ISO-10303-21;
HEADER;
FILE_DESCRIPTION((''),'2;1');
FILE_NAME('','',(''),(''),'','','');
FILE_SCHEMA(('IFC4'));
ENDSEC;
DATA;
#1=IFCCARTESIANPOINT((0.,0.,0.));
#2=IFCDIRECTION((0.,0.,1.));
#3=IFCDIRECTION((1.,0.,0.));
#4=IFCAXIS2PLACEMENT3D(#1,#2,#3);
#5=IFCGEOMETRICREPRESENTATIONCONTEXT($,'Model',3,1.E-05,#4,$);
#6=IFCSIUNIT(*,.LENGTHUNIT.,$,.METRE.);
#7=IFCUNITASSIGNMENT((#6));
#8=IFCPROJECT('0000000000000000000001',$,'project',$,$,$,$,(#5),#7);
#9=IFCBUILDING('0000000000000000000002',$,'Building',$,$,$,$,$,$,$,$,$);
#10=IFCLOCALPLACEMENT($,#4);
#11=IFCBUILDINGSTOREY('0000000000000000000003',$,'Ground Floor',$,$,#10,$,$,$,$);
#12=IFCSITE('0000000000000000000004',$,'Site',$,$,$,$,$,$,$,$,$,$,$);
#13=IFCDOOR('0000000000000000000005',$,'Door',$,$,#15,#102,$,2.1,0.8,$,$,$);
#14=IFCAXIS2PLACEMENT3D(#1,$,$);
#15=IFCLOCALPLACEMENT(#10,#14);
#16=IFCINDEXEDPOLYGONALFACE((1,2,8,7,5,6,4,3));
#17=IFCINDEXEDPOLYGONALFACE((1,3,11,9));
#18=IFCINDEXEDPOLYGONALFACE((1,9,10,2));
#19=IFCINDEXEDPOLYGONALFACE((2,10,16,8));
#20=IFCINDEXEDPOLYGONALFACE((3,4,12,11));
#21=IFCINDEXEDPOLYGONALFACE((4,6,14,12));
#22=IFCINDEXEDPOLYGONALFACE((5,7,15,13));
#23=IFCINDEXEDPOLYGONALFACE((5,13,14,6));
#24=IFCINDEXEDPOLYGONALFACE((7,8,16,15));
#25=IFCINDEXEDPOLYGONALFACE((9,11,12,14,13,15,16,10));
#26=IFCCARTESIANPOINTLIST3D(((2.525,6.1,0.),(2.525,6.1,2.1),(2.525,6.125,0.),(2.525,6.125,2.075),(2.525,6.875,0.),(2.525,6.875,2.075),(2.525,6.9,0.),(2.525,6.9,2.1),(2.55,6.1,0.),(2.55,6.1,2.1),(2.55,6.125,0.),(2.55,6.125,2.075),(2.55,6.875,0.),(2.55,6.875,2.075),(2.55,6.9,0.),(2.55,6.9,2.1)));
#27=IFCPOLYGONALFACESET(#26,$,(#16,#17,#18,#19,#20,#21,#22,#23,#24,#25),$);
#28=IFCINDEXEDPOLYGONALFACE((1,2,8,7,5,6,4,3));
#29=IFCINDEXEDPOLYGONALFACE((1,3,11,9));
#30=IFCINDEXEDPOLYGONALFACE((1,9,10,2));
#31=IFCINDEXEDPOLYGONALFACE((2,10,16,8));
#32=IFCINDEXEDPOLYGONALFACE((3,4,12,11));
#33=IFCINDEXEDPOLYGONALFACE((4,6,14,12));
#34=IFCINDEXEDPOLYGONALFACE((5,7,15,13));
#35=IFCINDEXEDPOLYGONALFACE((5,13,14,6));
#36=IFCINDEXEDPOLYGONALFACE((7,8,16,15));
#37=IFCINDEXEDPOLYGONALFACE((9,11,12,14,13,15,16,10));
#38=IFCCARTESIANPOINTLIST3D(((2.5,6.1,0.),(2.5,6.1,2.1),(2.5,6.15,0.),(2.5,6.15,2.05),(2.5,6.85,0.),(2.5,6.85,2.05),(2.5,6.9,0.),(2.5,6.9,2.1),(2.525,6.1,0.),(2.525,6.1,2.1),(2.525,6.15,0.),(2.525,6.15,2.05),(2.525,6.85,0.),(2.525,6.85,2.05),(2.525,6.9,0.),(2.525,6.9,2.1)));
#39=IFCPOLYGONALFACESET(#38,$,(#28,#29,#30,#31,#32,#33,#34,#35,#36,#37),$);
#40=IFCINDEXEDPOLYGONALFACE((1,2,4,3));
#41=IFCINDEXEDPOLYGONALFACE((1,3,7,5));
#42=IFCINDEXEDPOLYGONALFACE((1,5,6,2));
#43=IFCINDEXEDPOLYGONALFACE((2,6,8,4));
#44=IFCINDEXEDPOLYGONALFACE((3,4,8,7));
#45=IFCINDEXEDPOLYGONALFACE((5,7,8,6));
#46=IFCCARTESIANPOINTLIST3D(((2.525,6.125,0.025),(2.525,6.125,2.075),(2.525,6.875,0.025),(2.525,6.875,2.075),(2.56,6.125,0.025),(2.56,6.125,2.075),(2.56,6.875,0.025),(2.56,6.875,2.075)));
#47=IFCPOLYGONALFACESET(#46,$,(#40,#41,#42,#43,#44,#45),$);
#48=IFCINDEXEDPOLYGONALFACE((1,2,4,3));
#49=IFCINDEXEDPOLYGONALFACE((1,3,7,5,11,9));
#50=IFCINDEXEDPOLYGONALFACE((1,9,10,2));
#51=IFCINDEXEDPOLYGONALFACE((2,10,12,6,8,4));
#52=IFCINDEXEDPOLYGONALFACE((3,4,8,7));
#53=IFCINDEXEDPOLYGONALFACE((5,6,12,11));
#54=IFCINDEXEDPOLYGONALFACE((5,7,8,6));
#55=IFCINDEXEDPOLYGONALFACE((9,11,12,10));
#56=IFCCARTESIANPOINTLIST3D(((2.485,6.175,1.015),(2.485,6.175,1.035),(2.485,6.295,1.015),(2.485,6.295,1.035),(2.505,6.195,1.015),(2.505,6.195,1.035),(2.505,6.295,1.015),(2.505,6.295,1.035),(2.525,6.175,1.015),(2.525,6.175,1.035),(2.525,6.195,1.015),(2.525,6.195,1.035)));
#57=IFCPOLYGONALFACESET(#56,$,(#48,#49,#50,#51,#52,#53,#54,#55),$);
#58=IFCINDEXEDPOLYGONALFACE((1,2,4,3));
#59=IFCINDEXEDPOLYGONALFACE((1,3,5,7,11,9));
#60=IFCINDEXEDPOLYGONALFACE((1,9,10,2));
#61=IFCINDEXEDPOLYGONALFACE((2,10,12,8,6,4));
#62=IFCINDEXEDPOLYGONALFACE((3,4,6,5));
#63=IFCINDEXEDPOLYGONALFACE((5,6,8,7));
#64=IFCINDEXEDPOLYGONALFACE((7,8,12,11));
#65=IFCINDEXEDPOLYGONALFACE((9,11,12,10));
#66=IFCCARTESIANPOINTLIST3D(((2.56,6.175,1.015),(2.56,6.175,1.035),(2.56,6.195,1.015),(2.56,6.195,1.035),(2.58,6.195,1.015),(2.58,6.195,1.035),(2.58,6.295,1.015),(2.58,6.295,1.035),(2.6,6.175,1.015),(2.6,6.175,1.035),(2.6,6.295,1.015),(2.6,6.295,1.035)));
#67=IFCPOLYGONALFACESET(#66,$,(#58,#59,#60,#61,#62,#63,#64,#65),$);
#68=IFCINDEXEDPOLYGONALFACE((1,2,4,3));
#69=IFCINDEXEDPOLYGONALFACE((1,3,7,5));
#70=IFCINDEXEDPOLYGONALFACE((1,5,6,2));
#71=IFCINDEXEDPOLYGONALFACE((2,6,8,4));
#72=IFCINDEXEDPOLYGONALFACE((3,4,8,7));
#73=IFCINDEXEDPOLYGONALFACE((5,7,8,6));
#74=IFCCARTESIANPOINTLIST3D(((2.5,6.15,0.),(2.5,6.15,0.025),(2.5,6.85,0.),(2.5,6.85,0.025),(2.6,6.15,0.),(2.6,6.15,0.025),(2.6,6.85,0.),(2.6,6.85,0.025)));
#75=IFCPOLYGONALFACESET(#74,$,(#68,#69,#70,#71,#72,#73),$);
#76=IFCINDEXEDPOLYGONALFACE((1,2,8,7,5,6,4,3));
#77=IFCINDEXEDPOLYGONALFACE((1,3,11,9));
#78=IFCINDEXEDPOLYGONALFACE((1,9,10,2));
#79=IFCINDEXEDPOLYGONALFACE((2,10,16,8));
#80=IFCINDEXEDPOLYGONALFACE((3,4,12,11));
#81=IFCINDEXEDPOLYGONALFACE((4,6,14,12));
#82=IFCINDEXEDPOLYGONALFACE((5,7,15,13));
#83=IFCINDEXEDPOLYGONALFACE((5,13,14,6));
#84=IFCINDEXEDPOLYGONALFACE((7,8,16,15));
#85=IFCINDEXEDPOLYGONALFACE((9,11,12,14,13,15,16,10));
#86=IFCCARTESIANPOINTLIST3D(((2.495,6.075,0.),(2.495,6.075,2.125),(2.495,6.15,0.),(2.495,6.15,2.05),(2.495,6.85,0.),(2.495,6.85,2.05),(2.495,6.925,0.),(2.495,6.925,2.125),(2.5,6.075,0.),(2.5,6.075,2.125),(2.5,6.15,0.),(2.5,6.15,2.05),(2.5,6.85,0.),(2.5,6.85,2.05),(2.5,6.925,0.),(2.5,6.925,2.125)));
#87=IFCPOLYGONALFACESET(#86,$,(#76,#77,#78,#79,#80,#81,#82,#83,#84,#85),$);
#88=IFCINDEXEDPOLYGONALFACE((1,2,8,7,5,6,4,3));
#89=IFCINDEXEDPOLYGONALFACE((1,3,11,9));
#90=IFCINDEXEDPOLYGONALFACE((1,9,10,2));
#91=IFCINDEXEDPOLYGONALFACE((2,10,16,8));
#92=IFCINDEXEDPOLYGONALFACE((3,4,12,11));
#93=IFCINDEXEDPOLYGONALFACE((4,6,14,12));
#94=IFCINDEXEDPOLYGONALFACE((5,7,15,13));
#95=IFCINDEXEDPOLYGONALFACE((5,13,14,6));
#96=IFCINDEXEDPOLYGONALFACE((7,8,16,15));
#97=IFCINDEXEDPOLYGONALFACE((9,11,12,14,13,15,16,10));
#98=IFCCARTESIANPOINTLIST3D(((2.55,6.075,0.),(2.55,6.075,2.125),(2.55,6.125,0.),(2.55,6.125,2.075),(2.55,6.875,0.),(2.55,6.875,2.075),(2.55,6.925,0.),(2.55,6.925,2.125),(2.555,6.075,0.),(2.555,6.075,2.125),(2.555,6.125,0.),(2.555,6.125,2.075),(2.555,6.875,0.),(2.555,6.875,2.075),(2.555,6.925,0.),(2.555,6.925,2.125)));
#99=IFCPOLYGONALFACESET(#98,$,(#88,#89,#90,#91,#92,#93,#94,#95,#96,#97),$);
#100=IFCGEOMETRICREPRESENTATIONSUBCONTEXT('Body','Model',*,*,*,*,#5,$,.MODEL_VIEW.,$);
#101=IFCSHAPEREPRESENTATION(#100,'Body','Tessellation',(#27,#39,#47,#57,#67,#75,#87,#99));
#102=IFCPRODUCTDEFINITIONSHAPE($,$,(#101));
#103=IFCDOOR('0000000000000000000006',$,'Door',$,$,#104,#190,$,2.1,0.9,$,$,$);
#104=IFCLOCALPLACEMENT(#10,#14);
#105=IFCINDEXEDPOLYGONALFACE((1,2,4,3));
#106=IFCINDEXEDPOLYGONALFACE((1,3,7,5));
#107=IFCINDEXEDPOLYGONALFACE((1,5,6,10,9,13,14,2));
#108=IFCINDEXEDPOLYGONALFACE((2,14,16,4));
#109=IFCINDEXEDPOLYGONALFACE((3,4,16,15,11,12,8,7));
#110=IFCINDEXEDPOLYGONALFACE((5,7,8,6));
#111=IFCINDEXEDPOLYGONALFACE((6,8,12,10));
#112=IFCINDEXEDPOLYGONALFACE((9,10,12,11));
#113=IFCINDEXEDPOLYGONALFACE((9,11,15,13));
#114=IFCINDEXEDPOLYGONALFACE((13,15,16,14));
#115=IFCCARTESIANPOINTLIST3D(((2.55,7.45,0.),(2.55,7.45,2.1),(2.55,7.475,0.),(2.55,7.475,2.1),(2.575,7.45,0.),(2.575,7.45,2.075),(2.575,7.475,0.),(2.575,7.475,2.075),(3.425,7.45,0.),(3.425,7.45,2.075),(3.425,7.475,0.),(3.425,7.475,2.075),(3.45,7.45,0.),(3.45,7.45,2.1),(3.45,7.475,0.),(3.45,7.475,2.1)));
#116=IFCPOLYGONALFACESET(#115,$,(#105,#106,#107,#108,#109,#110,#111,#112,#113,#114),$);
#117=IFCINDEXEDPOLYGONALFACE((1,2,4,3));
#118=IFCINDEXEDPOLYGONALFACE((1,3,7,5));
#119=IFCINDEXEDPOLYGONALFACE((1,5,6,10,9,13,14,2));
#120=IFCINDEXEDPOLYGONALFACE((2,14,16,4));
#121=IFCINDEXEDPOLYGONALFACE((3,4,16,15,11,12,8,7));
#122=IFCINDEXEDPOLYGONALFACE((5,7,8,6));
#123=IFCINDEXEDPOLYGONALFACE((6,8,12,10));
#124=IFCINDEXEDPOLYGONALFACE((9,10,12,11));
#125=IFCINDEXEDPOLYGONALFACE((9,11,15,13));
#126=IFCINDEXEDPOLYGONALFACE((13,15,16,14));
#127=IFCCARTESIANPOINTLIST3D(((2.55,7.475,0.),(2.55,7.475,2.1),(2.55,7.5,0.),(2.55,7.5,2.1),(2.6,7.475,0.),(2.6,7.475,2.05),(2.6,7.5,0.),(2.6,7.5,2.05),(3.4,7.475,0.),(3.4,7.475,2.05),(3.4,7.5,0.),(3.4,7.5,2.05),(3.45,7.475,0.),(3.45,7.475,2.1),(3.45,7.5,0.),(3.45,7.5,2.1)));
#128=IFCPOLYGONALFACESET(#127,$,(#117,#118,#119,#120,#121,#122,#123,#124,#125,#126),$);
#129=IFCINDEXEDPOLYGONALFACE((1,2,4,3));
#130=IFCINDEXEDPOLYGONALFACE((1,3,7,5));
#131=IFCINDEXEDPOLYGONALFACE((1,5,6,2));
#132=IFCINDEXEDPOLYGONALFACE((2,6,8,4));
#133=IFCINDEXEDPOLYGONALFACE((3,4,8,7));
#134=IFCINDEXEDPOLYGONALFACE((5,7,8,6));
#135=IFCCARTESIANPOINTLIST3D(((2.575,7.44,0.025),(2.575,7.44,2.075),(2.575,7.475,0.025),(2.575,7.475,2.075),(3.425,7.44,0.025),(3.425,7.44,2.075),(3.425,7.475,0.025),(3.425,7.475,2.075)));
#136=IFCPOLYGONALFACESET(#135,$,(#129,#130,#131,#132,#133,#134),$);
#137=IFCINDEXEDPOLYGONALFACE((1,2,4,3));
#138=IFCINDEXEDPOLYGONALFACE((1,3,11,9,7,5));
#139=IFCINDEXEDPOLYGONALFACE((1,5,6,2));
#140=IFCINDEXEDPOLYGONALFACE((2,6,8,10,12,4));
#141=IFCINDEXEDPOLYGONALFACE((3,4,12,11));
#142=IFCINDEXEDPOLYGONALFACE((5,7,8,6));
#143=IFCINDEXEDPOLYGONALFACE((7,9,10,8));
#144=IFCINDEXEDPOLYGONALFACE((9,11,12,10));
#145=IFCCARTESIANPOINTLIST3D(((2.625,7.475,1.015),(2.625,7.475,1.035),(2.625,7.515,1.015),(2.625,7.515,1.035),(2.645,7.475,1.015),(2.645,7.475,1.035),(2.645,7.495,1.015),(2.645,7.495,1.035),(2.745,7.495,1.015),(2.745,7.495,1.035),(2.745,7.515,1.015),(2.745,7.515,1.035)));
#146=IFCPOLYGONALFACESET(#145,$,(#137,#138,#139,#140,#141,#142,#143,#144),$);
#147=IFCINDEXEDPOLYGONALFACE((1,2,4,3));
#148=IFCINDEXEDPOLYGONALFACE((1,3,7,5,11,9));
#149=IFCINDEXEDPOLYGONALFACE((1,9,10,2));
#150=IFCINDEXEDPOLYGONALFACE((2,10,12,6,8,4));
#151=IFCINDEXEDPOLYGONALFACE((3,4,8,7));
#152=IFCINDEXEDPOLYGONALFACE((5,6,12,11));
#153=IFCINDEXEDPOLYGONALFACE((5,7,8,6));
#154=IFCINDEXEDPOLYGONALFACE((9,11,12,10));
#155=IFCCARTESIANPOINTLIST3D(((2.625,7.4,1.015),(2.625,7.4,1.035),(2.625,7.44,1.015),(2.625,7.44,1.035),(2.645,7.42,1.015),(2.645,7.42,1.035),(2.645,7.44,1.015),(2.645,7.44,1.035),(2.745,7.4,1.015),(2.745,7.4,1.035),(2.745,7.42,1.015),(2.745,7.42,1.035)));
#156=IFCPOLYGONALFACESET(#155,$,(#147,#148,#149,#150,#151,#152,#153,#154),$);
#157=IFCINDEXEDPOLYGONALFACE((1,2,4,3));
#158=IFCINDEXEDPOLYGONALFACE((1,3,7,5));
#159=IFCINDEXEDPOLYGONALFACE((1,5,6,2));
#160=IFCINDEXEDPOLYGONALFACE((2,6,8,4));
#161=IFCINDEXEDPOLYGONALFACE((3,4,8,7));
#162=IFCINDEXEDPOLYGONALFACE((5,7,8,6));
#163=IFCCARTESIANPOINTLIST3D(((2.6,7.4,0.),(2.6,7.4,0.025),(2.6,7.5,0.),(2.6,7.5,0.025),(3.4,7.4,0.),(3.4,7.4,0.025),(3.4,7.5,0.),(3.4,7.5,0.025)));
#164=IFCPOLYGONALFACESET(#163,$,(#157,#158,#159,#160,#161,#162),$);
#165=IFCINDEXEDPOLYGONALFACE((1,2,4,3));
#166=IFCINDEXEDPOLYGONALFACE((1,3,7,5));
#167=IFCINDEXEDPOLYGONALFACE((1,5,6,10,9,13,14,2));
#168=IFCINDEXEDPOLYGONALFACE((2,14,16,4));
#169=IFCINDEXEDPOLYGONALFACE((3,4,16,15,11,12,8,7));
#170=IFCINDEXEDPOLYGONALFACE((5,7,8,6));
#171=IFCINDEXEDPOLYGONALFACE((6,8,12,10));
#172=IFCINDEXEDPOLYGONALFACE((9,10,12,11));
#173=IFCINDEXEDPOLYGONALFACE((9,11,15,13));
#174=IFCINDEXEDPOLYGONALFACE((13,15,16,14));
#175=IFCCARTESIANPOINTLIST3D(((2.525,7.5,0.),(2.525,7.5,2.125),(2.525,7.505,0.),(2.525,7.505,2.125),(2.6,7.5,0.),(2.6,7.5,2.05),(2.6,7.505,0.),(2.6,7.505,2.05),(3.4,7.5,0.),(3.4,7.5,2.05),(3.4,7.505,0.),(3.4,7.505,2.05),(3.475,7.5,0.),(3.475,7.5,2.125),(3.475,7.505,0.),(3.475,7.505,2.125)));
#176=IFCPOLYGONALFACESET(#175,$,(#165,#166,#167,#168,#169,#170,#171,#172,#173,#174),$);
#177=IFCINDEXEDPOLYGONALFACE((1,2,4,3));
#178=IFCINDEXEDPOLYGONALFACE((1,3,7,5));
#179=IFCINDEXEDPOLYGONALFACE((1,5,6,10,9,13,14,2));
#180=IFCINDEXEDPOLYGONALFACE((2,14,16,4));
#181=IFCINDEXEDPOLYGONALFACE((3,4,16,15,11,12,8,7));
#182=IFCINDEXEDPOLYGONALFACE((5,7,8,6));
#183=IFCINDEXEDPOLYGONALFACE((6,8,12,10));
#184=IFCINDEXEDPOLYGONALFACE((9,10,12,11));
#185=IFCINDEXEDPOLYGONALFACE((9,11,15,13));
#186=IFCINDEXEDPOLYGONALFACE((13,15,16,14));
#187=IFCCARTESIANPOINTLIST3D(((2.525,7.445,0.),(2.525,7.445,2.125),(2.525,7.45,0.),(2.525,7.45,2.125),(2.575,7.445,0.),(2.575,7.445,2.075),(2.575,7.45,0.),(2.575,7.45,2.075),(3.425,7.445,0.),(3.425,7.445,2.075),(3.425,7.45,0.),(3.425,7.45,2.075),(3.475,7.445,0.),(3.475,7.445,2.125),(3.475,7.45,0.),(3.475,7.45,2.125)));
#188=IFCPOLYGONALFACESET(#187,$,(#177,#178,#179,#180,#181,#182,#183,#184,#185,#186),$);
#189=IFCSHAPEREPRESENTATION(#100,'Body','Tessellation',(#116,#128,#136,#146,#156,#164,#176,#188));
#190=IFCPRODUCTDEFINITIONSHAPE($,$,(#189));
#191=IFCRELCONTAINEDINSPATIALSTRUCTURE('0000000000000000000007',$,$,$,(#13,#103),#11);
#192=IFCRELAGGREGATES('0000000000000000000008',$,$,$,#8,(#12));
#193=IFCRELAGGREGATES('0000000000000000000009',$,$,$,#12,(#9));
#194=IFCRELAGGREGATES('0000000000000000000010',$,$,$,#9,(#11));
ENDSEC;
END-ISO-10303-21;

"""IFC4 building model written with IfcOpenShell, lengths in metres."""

from ifc_helpers import new_model, si_unit, frame, origin_with_axes, place, context, subcontext, project, spatial, line, indexed_curve, outline, extrude, element, save


model = new_model("IFC4")

# Units and contexts
model_context = context("Model", 3, precision=1e-05, world=origin_with_axes())
body_context = subcontext(model_context, "Body", "Model", "MODEL_VIEW")
ifc_project = project(units=[si_unit("LENGTHUNIT", "METRE")], contexts=[model_context])

# Site, building, storey
site = spatial("IfcSite", under=ifc_project, Name="Site")
building = spatial("IfcBuilding", under=site, Name="Building")
storey_placement = place(None, origin_with_axes())
storey = spatial("IfcBuildingStorey", under=building, at=storey_placement, Name="Ground Floor")

# Doors
door_1_placement = place(storey_placement, frame((2.5, 6.9, 0.0), z_axis=(0.0, 0.0, 1.0), x_axis=(0.0, -1.0, 0.0)))
element("IfcDoor", 1, at=door_1_placement, inside=storey, Name="Door", OverallHeight=2.1, OverallWidth=0.8, context=body_context, shape_type="SweptSolid", body=[
    extrude(outline(indexed_curve([(0.0, 0.0), (0.0, 2.1), (0.8, 2.1), (0.8, 0.0), (0.775, 0.0), (0.775, 2.075), (0.025, 2.075), (0.025, 0.0)], segments=[line(1, 2, 3, 4, 5, 6, 7, 8, 1)])), frame((0.0, 0.025, 0.0), z_axis=(0.0, -1.0, 0.0), x_axis=(1.0, 0.0, 0.0)), (0.0, 0.0, -1.0), 0.025),
    extrude(outline(indexed_curve([(0.0, 0.0), (0.0, 2.1), (0.8, 2.1), (0.8, 0.0), (0.75, 0.0), (0.75, 2.05), (0.05, 2.05), (0.05, 0.0)], segments=[line(1, 2, 3, 4, 5, 6, 7, 8, 1)])), frame((0.0, 0.0, 0.0), z_axis=(0.0, -1.0, 0.0), x_axis=(1.0, 0.0, 0.0)), (0.0, 0.0, -1.0), 0.025),
    extrude(outline(indexed_curve([(0.0, 0.0), (0.75, 0.0), (0.75, 0.035), (0.0, 0.035)], segments=[line(1, 2, 3, 4, 1)])), frame((0.025, 0.025, 0.025), z_axis=(0.0, 0.0, 1.0), x_axis=(1.0, 0.0, 0.0)), (0.0, 0.0, 1.0), 2.05),
    extrude(outline(indexed_curve([(0.0, 0.0), (0.0, -0.04), (-0.12, -0.04), (-0.12, -0.02), (-0.02, -0.02), (-0.02, 0.0)], segments=[line(1, 2, 3, 4, 5, 6, 1)])), frame((0.725, 0.025, 1.015), z_axis=(0.0, 0.0, 1.0), x_axis=(1.0, 0.0, 0.0)), (0.0, 0.0, 1.0), 0.02),
    extrude(outline(indexed_curve([(0.0, 0.0), (0.0, 0.04), (-0.12, 0.04), (-0.12, 0.02), (-0.02, 0.02), (-0.02, 0.0)], segments=[line(1, 2, 3, 4, 5, 6, 1)])), frame((0.725, 0.06, 1.015), z_axis=(0.0, 0.0, 1.0), x_axis=(1.0, 0.0, 0.0)), (0.0, 0.0, 1.0), 0.02),
    extrude(outline(indexed_curve([(0.0, 0.0), (0.7, 0.0), (0.7, 0.1), (0.0, 0.1)], segments=[line(1, 2, 3, 4, 1)])), frame((0.05, 0.0, 0.0), z_axis=(0.0, 0.0, 1.0), x_axis=(1.0, 0.0, 0.0)), (0.0, 0.0, 1.0), 0.025),
    extrude(outline(indexed_curve([(0.0, 0.0), (0.0, 2.125), (0.85, 2.125), (0.85, 0.0), (0.775, 0.0), (0.775, 2.05), (0.075, 2.05), (0.075, 0.0)], segments=[line(1, 2, 3, 4, 5, 6, 7, 8, 1)])), frame((-0.025, -0.005, 0.0), z_axis=(0.0, -1.0, 0.0), x_axis=(1.0, 0.0, 0.0)), (0.0, 0.0, -1.0), 0.005),
    extrude(outline(indexed_curve([(0.0, 0.0), (0.0, 2.125), (0.85, 2.125), (0.85, 0.0), (0.8, 0.0), (0.8, 2.075), (0.05, 2.075), (0.05, 0.0)], segments=[line(1, 2, 3, 4, 5, 6, 7, 8, 1)])), frame((-0.025, 0.05, 0.0), z_axis=(0.0, -1.0, 0.0), x_axis=(1.0, 0.0, 0.0)), (0.0, 0.0, -1.0), 0.005),
])
door_2_placement = place(storey_placement, frame((3.45, 7.5, 0.0), z_axis=(0.0, 0.0, 1.0), x_axis=(-1.0, 0.0, 0.0)))
element("IfcDoor", 2, at=door_2_placement, inside=storey, Name="Door", OverallHeight=2.1, OverallWidth=0.9, context=body_context, shape_type="SweptSolid", body=[
    extrude(outline(indexed_curve([(0.0, 0.0), (0.0, 2.1), (0.9, 2.1), (0.9, 0.0), (0.875, 0.0), (0.875, 2.075), (0.025, 2.075), (0.025, 0.0)], segments=[line(1, 2, 3, 4, 5, 6, 7, 8, 1)])), frame((0.0, 0.025, 0.0), z_axis=(0.0, -1.0, 0.0), x_axis=(1.0, 0.0, 0.0)), (0.0, 0.0, -1.0), 0.025),
    extrude(outline(indexed_curve([(0.0, 0.0), (0.0, 2.1), (0.9, 2.1), (0.9, 0.0), (0.85, 0.0), (0.85, 2.05), (0.05, 2.05), (0.05, 0.0)], segments=[line(1, 2, 3, 4, 5, 6, 7, 8, 1)])), frame((0.0, 0.0, 0.0), z_axis=(0.0, -1.0, 0.0), x_axis=(1.0, 0.0, 0.0)), (0.0, 0.0, -1.0), 0.025),
    extrude(outline(indexed_curve([(0.0, 0.0), (0.85, 0.0), (0.85, 0.035), (0.0, 0.035)], segments=[line(1, 2, 3, 4, 1)])), frame((0.025, 0.025, 0.025), z_axis=(0.0, 0.0, 1.0), x_axis=(1.0, 0.0, 0.0)), (0.0, 0.0, 1.0), 2.05),
    extrude(outline(indexed_curve([(0.0, 0.0), (0.0, -0.04), (-0.12, -0.04), (-0.12, -0.02), (-0.02, -0.02), (-0.02, 0.0)], segments=[line(1, 2, 3, 4, 5, 6, 1)])), frame((0.825, 0.025, 1.015), z_axis=(0.0, 0.0, 1.0), x_axis=(1.0, 0.0, 0.0)), (0.0, 0.0, 1.0), 0.02),
    extrude(outline(indexed_curve([(0.0, 0.0), (0.0, 0.04), (-0.12, 0.04), (-0.12, 0.02), (-0.02, 0.02), (-0.02, 0.0)], segments=[line(1, 2, 3, 4, 5, 6, 1)])), frame((0.825, 0.06, 1.015), z_axis=(0.0, 0.0, 1.0), x_axis=(1.0, 0.0, 0.0)), (0.0, 0.0, 1.0), 0.02),
    extrude(outline(indexed_curve([(0.0, 0.0), (0.8, 0.0), (0.8, 0.1), (0.0, 0.1)], segments=[line(1, 2, 3, 4, 1)])), frame((0.05, 0.0, 0.0), z_axis=(0.0, 0.0, 1.0), x_axis=(1.0, 0.0, 0.0)), (0.0, 0.0, 1.0), 0.025),
    extrude(outline(indexed_curve([(0.0, 0.0), (0.0, 2.125), (0.95, 2.125), (0.95, 0.0), (0.875, 0.0), (0.875, 2.05), (0.075, 2.05), (0.075, 0.0)], segments=[line(1, 2, 3, 4, 5, 6, 7, 8, 1)])), frame((-0.025, -0.005, 0.0), z_axis=(0.0, -1.0, 0.0), x_axis=(1.0, 0.0, 0.0)), (0.0, 0.0, -1.0), 0.005),
    extrude(outline(indexed_curve([(0.0, 0.0), (0.0, 2.125), (0.95, 2.125), (0.95, 0.0), (0.9, 0.0), (0.9, 2.075), (0.05, 2.075), (0.05, 0.0)], segments=[line(1, 2, 3, 4, 5, 6, 7, 8, 1)])), frame((-0.025, 0.05, 0.0), z_axis=(0.0, -1.0, 0.0), x_axis=(1.0, 0.0, 0.0)), (0.0, 0.0, -1.0), 0.005),
])

save(model, "model.ifc")
